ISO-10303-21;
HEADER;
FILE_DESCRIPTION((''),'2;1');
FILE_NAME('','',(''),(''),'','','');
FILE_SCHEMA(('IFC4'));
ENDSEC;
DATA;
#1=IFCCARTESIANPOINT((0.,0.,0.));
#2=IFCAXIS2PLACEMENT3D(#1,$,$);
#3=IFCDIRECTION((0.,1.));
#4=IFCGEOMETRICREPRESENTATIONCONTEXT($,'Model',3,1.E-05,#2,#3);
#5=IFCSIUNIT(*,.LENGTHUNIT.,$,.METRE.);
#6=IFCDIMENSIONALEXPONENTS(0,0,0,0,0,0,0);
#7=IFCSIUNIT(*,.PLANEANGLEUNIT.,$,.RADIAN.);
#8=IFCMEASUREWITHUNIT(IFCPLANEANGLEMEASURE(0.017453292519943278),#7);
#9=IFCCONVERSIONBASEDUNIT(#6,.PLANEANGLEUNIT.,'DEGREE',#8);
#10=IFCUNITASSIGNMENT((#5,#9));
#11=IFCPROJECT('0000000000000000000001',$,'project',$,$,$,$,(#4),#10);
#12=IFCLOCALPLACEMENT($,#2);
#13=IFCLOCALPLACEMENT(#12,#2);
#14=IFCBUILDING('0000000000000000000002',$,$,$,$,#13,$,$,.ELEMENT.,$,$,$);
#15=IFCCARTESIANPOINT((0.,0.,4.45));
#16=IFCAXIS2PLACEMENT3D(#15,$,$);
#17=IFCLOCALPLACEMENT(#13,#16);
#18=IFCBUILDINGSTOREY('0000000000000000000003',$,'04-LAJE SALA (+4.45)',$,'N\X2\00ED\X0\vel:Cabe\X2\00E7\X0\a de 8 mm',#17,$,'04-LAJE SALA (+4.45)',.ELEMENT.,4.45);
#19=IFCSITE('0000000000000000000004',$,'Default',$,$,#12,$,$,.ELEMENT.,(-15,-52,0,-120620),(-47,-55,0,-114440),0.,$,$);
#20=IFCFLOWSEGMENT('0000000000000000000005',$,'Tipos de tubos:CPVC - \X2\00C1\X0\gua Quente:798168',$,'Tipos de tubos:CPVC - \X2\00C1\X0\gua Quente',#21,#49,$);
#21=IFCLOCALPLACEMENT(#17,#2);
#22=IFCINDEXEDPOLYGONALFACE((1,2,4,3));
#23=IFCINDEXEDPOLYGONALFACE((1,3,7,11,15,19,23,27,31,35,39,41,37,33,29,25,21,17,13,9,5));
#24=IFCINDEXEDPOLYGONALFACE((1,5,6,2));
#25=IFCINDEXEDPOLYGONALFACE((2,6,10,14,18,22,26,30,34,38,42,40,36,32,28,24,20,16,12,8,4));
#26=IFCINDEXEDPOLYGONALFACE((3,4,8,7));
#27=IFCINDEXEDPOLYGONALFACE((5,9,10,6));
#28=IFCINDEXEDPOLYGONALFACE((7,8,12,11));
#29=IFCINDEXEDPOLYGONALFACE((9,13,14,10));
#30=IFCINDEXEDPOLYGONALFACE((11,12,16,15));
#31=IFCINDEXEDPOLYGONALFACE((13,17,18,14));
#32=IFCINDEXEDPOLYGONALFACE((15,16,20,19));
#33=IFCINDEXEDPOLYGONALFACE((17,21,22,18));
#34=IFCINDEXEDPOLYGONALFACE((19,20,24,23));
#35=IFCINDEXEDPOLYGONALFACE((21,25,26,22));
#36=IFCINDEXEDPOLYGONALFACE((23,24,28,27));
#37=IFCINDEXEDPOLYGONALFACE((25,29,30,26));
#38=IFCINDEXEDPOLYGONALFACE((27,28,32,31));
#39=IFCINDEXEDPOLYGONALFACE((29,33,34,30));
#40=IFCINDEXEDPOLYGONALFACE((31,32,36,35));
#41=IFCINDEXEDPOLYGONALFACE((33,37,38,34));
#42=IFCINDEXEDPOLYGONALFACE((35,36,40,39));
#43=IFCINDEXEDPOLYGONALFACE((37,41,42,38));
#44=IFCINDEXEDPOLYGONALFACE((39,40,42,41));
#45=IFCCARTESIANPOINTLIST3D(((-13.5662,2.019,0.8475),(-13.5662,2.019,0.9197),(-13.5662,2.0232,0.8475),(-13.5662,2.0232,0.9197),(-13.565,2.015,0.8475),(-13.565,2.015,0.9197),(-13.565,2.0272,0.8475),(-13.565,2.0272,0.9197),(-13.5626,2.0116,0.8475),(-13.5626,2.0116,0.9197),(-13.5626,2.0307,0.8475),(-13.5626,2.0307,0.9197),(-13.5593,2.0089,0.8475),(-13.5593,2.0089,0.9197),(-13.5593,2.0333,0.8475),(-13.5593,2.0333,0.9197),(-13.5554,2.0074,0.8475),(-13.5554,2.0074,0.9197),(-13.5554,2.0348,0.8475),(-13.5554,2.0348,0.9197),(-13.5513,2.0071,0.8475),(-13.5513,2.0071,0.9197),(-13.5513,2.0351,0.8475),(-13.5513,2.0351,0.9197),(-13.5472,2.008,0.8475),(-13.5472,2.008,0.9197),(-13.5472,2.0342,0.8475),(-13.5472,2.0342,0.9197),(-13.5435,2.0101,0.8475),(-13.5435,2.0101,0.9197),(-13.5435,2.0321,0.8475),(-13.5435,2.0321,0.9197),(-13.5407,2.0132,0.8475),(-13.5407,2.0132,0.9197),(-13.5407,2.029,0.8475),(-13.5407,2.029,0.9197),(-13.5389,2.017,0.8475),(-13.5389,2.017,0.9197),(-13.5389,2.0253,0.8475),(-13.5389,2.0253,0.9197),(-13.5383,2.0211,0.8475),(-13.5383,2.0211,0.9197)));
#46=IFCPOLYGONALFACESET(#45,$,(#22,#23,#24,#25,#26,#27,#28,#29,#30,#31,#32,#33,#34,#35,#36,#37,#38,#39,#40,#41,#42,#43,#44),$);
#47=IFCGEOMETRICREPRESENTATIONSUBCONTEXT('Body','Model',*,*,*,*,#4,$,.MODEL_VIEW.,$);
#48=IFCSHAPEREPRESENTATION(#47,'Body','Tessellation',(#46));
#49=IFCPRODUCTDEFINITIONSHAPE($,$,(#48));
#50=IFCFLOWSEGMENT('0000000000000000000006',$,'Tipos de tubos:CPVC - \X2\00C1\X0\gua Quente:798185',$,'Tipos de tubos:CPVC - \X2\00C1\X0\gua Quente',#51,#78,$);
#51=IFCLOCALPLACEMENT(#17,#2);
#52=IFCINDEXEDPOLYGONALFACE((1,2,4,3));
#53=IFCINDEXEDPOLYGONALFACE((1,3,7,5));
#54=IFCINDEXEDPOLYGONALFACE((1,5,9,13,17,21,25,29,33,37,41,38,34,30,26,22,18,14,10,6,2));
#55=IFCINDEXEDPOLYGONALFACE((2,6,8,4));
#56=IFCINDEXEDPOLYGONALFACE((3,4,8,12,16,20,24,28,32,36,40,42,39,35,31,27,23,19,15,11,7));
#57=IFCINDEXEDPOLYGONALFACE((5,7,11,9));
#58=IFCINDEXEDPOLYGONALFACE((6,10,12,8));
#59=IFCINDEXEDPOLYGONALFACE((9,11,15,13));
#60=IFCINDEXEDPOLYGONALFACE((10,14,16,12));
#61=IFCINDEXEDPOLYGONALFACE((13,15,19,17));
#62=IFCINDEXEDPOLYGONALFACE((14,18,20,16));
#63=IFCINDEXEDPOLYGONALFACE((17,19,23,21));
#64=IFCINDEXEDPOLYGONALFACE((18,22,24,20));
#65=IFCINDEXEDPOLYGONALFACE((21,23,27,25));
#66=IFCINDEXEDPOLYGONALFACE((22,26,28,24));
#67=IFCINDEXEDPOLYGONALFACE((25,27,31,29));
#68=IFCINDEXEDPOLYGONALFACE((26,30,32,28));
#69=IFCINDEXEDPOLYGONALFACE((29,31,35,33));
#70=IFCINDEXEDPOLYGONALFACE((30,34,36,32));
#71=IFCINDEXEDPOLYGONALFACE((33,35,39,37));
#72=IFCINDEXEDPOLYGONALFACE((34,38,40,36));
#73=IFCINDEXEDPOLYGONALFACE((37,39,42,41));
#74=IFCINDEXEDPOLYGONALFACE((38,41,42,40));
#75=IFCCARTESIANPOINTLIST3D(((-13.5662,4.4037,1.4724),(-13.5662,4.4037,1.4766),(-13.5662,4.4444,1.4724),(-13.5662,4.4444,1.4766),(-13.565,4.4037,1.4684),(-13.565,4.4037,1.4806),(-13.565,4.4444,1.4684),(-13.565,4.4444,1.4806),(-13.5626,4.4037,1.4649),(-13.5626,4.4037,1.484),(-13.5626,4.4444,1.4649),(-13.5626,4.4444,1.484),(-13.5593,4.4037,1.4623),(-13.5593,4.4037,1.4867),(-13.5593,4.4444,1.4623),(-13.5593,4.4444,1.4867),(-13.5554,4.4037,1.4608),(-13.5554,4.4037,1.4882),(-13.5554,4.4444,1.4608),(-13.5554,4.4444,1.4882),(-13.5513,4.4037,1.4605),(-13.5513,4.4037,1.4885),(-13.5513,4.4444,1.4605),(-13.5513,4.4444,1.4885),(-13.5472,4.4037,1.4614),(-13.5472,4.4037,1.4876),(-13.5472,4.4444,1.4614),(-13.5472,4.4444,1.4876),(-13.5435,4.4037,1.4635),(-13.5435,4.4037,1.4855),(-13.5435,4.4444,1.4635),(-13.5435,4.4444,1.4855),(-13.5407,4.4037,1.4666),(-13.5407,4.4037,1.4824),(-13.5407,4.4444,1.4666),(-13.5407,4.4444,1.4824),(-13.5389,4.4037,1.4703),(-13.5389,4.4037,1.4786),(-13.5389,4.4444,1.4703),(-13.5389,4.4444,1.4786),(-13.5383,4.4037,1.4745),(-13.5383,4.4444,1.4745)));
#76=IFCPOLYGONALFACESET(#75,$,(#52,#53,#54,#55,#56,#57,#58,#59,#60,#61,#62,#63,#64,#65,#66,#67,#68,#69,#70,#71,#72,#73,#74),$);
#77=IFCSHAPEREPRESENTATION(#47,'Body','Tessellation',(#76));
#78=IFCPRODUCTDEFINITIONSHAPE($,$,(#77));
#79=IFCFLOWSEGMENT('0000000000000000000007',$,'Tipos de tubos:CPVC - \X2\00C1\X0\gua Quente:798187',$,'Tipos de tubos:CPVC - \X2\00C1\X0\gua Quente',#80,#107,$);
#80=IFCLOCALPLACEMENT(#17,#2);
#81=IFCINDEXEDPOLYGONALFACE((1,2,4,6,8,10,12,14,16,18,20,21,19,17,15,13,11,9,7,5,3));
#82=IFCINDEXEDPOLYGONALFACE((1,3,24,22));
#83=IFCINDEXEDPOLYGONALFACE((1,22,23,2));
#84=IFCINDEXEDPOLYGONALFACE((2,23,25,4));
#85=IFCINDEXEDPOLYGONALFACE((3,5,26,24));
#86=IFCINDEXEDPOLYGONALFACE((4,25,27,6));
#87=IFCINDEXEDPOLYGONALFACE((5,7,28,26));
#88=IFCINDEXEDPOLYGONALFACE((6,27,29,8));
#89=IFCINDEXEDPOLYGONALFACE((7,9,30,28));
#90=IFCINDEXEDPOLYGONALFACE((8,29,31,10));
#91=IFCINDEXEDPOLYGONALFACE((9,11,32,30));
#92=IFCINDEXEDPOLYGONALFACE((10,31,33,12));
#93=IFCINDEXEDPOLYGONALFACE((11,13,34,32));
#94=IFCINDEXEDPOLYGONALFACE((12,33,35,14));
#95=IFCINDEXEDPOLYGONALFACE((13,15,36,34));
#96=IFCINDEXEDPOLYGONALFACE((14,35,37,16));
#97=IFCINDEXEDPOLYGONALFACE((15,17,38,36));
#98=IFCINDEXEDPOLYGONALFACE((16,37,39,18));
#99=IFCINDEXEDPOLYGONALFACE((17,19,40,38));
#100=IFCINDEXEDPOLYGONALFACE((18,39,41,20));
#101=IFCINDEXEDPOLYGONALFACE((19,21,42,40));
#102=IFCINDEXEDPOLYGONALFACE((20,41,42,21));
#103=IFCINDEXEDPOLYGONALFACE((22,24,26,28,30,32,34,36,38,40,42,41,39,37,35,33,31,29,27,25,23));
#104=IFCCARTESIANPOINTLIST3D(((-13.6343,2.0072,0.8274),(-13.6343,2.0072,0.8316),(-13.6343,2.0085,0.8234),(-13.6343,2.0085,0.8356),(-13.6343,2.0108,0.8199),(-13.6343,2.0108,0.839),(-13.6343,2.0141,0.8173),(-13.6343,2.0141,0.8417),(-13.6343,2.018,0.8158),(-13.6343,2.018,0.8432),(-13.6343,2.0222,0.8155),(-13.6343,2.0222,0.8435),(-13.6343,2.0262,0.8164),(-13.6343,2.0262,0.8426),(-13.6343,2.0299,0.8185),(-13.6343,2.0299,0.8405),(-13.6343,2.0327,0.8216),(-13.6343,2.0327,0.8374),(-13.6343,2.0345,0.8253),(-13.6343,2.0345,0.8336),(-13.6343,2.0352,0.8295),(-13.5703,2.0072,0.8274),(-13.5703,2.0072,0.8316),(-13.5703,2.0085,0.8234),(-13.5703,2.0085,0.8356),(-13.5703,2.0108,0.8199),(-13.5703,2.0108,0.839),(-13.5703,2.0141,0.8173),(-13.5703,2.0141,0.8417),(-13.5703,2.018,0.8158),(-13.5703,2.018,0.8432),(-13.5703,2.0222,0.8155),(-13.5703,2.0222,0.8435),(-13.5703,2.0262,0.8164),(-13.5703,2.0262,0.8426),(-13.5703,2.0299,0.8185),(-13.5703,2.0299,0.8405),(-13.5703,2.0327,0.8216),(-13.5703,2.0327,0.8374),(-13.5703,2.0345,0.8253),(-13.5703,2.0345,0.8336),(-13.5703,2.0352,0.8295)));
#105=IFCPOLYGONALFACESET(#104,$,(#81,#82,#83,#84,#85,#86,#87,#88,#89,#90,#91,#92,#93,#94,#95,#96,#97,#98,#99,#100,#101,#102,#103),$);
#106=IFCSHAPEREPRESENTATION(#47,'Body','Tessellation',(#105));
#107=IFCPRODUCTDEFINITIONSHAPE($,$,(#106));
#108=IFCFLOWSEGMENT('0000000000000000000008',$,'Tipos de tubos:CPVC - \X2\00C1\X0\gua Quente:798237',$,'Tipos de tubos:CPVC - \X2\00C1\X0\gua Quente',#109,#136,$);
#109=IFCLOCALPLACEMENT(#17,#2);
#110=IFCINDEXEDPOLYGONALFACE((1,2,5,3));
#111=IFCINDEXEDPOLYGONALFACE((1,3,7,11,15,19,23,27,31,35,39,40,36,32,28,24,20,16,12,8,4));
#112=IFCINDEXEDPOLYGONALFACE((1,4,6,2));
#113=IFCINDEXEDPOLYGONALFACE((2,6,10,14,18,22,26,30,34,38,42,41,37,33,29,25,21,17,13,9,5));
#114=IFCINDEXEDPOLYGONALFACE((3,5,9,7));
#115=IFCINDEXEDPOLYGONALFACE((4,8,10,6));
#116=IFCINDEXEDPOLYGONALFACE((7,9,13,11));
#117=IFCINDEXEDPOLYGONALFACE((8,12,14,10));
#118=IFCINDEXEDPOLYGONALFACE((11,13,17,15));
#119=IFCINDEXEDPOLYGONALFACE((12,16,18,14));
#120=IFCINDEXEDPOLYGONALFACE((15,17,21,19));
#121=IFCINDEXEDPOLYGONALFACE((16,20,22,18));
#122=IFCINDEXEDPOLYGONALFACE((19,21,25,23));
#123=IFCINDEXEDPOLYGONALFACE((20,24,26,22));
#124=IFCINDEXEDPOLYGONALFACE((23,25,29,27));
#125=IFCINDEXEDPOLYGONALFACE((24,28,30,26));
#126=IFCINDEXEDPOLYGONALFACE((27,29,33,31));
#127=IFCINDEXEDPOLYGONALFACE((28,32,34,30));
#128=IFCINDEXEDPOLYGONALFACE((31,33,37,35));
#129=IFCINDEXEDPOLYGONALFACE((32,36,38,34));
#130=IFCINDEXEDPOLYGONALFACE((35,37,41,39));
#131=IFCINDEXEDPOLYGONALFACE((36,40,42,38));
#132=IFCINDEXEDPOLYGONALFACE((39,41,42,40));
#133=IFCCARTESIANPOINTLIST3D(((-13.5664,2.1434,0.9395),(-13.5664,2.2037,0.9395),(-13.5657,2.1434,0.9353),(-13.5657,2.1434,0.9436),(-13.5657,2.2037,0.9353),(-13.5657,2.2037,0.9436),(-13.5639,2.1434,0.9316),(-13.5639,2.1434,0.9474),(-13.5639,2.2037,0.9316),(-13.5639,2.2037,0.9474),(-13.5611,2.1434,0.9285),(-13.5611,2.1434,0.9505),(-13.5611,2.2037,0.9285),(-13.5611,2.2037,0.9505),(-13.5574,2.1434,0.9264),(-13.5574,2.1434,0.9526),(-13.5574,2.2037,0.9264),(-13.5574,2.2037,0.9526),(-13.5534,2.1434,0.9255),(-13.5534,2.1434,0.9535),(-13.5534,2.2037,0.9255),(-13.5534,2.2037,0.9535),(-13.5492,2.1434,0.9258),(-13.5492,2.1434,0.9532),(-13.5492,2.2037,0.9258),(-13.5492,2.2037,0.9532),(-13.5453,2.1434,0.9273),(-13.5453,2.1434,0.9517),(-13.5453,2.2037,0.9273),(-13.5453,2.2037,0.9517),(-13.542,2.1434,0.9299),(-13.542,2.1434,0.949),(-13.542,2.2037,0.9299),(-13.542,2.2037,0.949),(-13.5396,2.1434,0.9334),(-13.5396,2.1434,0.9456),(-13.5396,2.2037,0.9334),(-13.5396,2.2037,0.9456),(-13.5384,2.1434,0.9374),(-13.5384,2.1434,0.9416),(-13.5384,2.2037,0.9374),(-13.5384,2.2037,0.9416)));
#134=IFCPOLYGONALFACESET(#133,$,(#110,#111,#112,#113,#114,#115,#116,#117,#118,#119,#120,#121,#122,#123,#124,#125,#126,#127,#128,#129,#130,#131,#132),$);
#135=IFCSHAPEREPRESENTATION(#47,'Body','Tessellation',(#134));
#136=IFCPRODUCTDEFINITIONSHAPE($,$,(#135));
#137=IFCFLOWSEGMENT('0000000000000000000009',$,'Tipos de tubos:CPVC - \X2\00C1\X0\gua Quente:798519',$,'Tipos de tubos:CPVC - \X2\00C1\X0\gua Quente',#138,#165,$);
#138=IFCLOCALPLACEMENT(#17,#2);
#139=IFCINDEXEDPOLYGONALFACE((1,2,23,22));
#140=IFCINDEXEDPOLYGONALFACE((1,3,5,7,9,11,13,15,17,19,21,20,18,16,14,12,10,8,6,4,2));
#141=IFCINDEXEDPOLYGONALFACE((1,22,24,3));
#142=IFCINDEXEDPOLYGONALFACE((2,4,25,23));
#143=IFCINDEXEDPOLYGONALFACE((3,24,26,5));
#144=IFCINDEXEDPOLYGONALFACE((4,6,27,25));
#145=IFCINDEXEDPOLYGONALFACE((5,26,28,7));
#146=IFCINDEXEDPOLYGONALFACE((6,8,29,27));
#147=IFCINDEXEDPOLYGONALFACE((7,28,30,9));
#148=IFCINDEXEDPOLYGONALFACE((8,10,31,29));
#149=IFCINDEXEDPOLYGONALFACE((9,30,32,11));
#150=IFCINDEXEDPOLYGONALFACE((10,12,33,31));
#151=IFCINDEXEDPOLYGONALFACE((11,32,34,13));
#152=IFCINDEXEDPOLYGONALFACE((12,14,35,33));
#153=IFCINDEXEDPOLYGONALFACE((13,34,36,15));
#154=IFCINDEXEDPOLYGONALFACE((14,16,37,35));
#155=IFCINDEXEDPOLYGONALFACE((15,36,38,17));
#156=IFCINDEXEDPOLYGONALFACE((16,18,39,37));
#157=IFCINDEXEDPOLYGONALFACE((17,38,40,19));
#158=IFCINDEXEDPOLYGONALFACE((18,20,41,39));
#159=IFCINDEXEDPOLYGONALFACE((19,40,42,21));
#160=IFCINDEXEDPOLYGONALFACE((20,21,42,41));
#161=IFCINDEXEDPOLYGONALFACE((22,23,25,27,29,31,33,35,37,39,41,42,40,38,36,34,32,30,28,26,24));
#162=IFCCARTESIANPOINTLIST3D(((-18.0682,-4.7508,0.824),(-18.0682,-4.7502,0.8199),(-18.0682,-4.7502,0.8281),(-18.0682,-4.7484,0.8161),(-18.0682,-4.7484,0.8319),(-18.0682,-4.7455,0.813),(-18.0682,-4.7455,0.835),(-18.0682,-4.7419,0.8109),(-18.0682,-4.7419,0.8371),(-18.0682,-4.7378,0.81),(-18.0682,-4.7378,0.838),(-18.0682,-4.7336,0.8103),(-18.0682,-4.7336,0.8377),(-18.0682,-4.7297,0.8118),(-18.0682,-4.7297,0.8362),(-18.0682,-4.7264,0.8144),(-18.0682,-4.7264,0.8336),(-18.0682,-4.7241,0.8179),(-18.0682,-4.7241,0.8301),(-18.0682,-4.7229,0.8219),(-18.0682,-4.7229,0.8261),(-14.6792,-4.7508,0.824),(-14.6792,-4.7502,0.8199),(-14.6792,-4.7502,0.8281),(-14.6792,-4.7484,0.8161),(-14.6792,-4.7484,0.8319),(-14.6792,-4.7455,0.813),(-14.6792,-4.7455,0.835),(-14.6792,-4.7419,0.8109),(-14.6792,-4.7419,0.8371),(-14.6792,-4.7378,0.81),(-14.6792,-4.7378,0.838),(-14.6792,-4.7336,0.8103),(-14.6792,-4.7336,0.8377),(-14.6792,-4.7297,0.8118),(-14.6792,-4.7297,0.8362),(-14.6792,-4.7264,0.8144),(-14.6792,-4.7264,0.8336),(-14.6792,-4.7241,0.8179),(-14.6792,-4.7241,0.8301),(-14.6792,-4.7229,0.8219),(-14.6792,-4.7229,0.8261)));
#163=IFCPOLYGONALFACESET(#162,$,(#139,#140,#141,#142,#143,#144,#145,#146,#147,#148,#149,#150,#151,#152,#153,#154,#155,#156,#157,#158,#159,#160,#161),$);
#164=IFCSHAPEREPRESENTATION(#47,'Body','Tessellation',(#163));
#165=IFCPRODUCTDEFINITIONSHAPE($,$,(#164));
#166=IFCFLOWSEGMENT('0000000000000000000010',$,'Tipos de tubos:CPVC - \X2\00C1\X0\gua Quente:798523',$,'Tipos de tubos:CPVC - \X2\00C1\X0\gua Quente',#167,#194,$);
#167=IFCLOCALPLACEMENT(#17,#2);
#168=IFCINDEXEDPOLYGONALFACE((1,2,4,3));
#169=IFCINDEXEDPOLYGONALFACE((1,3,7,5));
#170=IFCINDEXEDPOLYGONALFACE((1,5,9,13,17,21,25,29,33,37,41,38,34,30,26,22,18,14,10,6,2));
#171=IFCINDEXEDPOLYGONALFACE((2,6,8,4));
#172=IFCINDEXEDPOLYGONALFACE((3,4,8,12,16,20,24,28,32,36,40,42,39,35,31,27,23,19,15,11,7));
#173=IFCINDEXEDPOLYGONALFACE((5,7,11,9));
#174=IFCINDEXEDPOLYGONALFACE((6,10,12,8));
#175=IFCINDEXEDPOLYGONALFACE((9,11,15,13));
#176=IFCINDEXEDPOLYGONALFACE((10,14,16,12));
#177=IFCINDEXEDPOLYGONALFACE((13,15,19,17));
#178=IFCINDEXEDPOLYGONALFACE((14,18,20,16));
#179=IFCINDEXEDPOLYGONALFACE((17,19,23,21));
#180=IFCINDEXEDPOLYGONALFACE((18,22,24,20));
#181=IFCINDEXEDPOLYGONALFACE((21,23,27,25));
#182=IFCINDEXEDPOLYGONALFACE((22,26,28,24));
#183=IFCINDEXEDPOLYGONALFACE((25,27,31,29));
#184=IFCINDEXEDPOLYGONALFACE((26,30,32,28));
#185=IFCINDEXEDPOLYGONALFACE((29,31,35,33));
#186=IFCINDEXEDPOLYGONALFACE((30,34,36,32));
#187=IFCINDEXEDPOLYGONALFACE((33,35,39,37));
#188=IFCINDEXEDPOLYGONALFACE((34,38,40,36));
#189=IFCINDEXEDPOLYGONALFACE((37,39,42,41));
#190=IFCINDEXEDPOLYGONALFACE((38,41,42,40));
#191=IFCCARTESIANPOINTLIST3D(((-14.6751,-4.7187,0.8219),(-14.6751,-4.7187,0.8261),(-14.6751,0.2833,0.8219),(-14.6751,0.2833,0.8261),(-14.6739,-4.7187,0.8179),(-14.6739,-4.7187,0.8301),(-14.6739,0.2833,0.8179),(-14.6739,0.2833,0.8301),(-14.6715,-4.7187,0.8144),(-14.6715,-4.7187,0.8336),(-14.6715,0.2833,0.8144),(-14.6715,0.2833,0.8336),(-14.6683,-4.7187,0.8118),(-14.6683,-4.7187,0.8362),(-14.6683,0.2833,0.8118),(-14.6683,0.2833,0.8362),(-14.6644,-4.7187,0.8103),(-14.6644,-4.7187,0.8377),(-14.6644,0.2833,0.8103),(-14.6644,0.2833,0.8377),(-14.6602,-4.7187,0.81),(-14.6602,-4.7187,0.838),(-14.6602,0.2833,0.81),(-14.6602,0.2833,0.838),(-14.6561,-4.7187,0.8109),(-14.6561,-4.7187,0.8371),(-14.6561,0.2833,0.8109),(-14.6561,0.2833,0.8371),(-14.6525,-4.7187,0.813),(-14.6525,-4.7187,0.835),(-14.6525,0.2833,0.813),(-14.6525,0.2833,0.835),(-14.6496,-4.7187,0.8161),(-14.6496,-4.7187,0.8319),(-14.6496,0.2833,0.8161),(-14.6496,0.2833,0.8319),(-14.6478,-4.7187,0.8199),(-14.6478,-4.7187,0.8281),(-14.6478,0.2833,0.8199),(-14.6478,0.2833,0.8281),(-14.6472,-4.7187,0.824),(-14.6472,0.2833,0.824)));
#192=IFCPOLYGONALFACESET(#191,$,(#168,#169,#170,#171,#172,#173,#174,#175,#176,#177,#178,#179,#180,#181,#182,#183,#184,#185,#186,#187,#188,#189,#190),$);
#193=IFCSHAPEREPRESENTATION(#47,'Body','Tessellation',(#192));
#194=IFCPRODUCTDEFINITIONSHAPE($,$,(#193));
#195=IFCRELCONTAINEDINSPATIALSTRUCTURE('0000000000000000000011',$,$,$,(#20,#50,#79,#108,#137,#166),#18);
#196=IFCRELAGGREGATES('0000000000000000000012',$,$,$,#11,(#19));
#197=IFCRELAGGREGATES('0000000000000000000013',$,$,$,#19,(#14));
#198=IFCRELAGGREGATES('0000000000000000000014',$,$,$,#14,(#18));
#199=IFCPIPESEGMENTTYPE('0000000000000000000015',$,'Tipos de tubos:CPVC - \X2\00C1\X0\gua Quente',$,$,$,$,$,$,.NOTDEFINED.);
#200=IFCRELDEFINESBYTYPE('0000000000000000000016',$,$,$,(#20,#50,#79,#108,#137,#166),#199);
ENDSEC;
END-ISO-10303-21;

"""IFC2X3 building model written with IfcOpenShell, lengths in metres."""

from ifc_helpers import new_model, entity, si_unit, converted_unit, direction, frame, frame_2d, origin, origin_2d_with_axis, place, context, subcontext, project, spatial, circle, extrude, type_object, element, save


model = new_model("IFC2X3")

# Units and contexts
model_context = context("Model", 3, precision=1e-05, world=origin(), true_north=direction((0.0, 1.0)))
body_context = subcontext(model_context, "Body", "Model", "MODEL_VIEW")
ifc_project = project(units=[si_unit("LENGTHUNIT", "METRE"), converted_unit("PLANEANGLEUNIT", "DEGREE", entity("IfcPlaneAngleMeasure", 0.017453292519943278), si_unit("PLANEANGLEUNIT", "RADIAN"), dimensions=[0, 0, 0, 0, 0, 0, 0])], contexts=[model_context])

# Site, building, storey
site_placement = place(None, origin())
site = spatial("IfcSite", under=ifc_project, at=site_placement, Name="Default", CompositionType="ELEMENT", RefLatitude=(-15, -52, 0, -120620), RefLongitude=(-47, -55, 0, -114440), RefElevation=0.0)
building_placement = place(site_placement, origin())
building = spatial("IfcBuilding", under=site, at=building_placement, CompositionType="ELEMENT")
storey_placement = place(building_placement, frame((0.0, 0.0, 4.45)))
storey = spatial("IfcBuildingStorey", under=building, at=storey_placement, Name="04-LAJE SALA (+4.45)", ObjectType="Nível:Cabeça de 8 mm", LongName="04-LAJE SALA (+4.45)", CompositionType="ELEMENT", Elevation=4.45)

# Flow segments
pipe_segment_type_1 = type_object("IfcPipeSegmentType", Name="Tipos de tubos:CPVC - Água Quente", PredefinedType="NOTDEFINED")
flow_segment_1_placement = place(storey_placement, origin())
element("IfcFlowSegment", 1, at=flow_segment_1_placement, inside=storey, type_object=pipe_segment_type_1, Name="Tipos de tubos:CPVC - Água Quente:798168", ObjectType="Tipos de tubos:CPVC - Água Quente", context=body_context, shape_type="SweptSolid", body=[
    extrude(circle(Radius=0.0141, at=frame_2d((0.0, 0.0), x_axis=(1.0, 0.0))), frame((-13.5523, 2.0211, 0.8475)), (0.0, 0.0, 1.0), 0.0722),
])
flow_segment_2_placement = place(storey_placement, origin())
element("IfcFlowSegment", 2, at=flow_segment_2_placement, inside=storey, type_object=pipe_segment_type_1, Name="Tipos de tubos:CPVC - Água Quente:798185", ObjectType="Tipos de tubos:CPVC - Água Quente", context=body_context, shape_type="SweptSolid", body=[
    extrude(circle(Radius=0.0141, at=origin_2d_with_axis()), frame((-13.5523, 4.4037, 1.4745), z_axis=(0.0, 1.0, 0.0), x_axis=(1.0, 0.0, 0.0)), (0.0, 0.0, 1.0), 0.0407),
])
flow_segment_3_placement = place(storey_placement, origin())
element("IfcFlowSegment", 3, at=flow_segment_3_placement, inside=storey, type_object=pipe_segment_type_1, Name="Tipos de tubos:CPVC - Água Quente:798187", ObjectType="Tipos de tubos:CPVC - Água Quente", context=body_context, shape_type="SweptSolid", body=[
    extrude(circle(Radius=0.0141, at=frame_2d((0.0, 0.0), x_axis=(1.0, 0.0))), frame((-13.6343, 2.0211, 0.8295), z_axis=(1.0, 0.0, 0.0), x_axis=(0.0, 1.0, 0.0)), (0.0, 0.0, 1.0), 0.064),
])
flow_segment_4_placement = place(storey_placement, origin())
element("IfcFlowSegment", 4, at=flow_segment_4_placement, inside=storey, type_object=pipe_segment_type_1, Name="Tipos de tubos:CPVC - Água Quente:798237", ObjectType="Tipos de tubos:CPVC - Água Quente", context=body_context, shape_type="SweptSolid", body=[
    extrude(circle(Radius=0.0141, at=frame_2d((0.0, 0.0), x_axis=(1.0, 0.0))), frame((-13.5523, 2.1434, 0.9395), z_axis=(0.0, 1.0, 0.0), x_axis=(-1.0, 0.0, 0.0)), (0.0, 0.0, 1.0), 0.0603),
])
flow_segment_5_placement = place(storey_placement, origin())
element("IfcFlowSegment", 5, at=flow_segment_5_placement, inside=storey, type_object=pipe_segment_type_1, Name="Tipos de tubos:CPVC - Água Quente:798519", ObjectType="Tipos de tubos:CPVC - Água Quente", context=body_context, shape_type="SweptSolid", body=[
    extrude(circle(Radius=0.0141, at=origin_2d_with_axis()), frame((-18.0682, -4.7367, 0.824), z_axis=(1.0, 0.0, 0.0), x_axis=(0.0, -1.0, 0.0)), (0.0, 0.0, 1.0), 3.389),
])
flow_segment_6_placement = place(storey_placement, origin())
element("IfcFlowSegment", 6, at=flow_segment_6_placement, inside=storey, type_object=pipe_segment_type_1, Name="Tipos de tubos:CPVC - Água Quente:798523", ObjectType="Tipos de tubos:CPVC - Água Quente", context=body_context, shape_type="SweptSolid", body=[
    extrude(circle(Radius=0.0141, at=origin_2d_with_axis()), frame((-14.6612, -4.7187, 0.824), z_axis=(0.0, 1.0, 0.0), x_axis=(1.0, 0.0, 0.0)), (0.0, 0.0, 1.0), 5.002),
])

save(model, "model.ifc")
